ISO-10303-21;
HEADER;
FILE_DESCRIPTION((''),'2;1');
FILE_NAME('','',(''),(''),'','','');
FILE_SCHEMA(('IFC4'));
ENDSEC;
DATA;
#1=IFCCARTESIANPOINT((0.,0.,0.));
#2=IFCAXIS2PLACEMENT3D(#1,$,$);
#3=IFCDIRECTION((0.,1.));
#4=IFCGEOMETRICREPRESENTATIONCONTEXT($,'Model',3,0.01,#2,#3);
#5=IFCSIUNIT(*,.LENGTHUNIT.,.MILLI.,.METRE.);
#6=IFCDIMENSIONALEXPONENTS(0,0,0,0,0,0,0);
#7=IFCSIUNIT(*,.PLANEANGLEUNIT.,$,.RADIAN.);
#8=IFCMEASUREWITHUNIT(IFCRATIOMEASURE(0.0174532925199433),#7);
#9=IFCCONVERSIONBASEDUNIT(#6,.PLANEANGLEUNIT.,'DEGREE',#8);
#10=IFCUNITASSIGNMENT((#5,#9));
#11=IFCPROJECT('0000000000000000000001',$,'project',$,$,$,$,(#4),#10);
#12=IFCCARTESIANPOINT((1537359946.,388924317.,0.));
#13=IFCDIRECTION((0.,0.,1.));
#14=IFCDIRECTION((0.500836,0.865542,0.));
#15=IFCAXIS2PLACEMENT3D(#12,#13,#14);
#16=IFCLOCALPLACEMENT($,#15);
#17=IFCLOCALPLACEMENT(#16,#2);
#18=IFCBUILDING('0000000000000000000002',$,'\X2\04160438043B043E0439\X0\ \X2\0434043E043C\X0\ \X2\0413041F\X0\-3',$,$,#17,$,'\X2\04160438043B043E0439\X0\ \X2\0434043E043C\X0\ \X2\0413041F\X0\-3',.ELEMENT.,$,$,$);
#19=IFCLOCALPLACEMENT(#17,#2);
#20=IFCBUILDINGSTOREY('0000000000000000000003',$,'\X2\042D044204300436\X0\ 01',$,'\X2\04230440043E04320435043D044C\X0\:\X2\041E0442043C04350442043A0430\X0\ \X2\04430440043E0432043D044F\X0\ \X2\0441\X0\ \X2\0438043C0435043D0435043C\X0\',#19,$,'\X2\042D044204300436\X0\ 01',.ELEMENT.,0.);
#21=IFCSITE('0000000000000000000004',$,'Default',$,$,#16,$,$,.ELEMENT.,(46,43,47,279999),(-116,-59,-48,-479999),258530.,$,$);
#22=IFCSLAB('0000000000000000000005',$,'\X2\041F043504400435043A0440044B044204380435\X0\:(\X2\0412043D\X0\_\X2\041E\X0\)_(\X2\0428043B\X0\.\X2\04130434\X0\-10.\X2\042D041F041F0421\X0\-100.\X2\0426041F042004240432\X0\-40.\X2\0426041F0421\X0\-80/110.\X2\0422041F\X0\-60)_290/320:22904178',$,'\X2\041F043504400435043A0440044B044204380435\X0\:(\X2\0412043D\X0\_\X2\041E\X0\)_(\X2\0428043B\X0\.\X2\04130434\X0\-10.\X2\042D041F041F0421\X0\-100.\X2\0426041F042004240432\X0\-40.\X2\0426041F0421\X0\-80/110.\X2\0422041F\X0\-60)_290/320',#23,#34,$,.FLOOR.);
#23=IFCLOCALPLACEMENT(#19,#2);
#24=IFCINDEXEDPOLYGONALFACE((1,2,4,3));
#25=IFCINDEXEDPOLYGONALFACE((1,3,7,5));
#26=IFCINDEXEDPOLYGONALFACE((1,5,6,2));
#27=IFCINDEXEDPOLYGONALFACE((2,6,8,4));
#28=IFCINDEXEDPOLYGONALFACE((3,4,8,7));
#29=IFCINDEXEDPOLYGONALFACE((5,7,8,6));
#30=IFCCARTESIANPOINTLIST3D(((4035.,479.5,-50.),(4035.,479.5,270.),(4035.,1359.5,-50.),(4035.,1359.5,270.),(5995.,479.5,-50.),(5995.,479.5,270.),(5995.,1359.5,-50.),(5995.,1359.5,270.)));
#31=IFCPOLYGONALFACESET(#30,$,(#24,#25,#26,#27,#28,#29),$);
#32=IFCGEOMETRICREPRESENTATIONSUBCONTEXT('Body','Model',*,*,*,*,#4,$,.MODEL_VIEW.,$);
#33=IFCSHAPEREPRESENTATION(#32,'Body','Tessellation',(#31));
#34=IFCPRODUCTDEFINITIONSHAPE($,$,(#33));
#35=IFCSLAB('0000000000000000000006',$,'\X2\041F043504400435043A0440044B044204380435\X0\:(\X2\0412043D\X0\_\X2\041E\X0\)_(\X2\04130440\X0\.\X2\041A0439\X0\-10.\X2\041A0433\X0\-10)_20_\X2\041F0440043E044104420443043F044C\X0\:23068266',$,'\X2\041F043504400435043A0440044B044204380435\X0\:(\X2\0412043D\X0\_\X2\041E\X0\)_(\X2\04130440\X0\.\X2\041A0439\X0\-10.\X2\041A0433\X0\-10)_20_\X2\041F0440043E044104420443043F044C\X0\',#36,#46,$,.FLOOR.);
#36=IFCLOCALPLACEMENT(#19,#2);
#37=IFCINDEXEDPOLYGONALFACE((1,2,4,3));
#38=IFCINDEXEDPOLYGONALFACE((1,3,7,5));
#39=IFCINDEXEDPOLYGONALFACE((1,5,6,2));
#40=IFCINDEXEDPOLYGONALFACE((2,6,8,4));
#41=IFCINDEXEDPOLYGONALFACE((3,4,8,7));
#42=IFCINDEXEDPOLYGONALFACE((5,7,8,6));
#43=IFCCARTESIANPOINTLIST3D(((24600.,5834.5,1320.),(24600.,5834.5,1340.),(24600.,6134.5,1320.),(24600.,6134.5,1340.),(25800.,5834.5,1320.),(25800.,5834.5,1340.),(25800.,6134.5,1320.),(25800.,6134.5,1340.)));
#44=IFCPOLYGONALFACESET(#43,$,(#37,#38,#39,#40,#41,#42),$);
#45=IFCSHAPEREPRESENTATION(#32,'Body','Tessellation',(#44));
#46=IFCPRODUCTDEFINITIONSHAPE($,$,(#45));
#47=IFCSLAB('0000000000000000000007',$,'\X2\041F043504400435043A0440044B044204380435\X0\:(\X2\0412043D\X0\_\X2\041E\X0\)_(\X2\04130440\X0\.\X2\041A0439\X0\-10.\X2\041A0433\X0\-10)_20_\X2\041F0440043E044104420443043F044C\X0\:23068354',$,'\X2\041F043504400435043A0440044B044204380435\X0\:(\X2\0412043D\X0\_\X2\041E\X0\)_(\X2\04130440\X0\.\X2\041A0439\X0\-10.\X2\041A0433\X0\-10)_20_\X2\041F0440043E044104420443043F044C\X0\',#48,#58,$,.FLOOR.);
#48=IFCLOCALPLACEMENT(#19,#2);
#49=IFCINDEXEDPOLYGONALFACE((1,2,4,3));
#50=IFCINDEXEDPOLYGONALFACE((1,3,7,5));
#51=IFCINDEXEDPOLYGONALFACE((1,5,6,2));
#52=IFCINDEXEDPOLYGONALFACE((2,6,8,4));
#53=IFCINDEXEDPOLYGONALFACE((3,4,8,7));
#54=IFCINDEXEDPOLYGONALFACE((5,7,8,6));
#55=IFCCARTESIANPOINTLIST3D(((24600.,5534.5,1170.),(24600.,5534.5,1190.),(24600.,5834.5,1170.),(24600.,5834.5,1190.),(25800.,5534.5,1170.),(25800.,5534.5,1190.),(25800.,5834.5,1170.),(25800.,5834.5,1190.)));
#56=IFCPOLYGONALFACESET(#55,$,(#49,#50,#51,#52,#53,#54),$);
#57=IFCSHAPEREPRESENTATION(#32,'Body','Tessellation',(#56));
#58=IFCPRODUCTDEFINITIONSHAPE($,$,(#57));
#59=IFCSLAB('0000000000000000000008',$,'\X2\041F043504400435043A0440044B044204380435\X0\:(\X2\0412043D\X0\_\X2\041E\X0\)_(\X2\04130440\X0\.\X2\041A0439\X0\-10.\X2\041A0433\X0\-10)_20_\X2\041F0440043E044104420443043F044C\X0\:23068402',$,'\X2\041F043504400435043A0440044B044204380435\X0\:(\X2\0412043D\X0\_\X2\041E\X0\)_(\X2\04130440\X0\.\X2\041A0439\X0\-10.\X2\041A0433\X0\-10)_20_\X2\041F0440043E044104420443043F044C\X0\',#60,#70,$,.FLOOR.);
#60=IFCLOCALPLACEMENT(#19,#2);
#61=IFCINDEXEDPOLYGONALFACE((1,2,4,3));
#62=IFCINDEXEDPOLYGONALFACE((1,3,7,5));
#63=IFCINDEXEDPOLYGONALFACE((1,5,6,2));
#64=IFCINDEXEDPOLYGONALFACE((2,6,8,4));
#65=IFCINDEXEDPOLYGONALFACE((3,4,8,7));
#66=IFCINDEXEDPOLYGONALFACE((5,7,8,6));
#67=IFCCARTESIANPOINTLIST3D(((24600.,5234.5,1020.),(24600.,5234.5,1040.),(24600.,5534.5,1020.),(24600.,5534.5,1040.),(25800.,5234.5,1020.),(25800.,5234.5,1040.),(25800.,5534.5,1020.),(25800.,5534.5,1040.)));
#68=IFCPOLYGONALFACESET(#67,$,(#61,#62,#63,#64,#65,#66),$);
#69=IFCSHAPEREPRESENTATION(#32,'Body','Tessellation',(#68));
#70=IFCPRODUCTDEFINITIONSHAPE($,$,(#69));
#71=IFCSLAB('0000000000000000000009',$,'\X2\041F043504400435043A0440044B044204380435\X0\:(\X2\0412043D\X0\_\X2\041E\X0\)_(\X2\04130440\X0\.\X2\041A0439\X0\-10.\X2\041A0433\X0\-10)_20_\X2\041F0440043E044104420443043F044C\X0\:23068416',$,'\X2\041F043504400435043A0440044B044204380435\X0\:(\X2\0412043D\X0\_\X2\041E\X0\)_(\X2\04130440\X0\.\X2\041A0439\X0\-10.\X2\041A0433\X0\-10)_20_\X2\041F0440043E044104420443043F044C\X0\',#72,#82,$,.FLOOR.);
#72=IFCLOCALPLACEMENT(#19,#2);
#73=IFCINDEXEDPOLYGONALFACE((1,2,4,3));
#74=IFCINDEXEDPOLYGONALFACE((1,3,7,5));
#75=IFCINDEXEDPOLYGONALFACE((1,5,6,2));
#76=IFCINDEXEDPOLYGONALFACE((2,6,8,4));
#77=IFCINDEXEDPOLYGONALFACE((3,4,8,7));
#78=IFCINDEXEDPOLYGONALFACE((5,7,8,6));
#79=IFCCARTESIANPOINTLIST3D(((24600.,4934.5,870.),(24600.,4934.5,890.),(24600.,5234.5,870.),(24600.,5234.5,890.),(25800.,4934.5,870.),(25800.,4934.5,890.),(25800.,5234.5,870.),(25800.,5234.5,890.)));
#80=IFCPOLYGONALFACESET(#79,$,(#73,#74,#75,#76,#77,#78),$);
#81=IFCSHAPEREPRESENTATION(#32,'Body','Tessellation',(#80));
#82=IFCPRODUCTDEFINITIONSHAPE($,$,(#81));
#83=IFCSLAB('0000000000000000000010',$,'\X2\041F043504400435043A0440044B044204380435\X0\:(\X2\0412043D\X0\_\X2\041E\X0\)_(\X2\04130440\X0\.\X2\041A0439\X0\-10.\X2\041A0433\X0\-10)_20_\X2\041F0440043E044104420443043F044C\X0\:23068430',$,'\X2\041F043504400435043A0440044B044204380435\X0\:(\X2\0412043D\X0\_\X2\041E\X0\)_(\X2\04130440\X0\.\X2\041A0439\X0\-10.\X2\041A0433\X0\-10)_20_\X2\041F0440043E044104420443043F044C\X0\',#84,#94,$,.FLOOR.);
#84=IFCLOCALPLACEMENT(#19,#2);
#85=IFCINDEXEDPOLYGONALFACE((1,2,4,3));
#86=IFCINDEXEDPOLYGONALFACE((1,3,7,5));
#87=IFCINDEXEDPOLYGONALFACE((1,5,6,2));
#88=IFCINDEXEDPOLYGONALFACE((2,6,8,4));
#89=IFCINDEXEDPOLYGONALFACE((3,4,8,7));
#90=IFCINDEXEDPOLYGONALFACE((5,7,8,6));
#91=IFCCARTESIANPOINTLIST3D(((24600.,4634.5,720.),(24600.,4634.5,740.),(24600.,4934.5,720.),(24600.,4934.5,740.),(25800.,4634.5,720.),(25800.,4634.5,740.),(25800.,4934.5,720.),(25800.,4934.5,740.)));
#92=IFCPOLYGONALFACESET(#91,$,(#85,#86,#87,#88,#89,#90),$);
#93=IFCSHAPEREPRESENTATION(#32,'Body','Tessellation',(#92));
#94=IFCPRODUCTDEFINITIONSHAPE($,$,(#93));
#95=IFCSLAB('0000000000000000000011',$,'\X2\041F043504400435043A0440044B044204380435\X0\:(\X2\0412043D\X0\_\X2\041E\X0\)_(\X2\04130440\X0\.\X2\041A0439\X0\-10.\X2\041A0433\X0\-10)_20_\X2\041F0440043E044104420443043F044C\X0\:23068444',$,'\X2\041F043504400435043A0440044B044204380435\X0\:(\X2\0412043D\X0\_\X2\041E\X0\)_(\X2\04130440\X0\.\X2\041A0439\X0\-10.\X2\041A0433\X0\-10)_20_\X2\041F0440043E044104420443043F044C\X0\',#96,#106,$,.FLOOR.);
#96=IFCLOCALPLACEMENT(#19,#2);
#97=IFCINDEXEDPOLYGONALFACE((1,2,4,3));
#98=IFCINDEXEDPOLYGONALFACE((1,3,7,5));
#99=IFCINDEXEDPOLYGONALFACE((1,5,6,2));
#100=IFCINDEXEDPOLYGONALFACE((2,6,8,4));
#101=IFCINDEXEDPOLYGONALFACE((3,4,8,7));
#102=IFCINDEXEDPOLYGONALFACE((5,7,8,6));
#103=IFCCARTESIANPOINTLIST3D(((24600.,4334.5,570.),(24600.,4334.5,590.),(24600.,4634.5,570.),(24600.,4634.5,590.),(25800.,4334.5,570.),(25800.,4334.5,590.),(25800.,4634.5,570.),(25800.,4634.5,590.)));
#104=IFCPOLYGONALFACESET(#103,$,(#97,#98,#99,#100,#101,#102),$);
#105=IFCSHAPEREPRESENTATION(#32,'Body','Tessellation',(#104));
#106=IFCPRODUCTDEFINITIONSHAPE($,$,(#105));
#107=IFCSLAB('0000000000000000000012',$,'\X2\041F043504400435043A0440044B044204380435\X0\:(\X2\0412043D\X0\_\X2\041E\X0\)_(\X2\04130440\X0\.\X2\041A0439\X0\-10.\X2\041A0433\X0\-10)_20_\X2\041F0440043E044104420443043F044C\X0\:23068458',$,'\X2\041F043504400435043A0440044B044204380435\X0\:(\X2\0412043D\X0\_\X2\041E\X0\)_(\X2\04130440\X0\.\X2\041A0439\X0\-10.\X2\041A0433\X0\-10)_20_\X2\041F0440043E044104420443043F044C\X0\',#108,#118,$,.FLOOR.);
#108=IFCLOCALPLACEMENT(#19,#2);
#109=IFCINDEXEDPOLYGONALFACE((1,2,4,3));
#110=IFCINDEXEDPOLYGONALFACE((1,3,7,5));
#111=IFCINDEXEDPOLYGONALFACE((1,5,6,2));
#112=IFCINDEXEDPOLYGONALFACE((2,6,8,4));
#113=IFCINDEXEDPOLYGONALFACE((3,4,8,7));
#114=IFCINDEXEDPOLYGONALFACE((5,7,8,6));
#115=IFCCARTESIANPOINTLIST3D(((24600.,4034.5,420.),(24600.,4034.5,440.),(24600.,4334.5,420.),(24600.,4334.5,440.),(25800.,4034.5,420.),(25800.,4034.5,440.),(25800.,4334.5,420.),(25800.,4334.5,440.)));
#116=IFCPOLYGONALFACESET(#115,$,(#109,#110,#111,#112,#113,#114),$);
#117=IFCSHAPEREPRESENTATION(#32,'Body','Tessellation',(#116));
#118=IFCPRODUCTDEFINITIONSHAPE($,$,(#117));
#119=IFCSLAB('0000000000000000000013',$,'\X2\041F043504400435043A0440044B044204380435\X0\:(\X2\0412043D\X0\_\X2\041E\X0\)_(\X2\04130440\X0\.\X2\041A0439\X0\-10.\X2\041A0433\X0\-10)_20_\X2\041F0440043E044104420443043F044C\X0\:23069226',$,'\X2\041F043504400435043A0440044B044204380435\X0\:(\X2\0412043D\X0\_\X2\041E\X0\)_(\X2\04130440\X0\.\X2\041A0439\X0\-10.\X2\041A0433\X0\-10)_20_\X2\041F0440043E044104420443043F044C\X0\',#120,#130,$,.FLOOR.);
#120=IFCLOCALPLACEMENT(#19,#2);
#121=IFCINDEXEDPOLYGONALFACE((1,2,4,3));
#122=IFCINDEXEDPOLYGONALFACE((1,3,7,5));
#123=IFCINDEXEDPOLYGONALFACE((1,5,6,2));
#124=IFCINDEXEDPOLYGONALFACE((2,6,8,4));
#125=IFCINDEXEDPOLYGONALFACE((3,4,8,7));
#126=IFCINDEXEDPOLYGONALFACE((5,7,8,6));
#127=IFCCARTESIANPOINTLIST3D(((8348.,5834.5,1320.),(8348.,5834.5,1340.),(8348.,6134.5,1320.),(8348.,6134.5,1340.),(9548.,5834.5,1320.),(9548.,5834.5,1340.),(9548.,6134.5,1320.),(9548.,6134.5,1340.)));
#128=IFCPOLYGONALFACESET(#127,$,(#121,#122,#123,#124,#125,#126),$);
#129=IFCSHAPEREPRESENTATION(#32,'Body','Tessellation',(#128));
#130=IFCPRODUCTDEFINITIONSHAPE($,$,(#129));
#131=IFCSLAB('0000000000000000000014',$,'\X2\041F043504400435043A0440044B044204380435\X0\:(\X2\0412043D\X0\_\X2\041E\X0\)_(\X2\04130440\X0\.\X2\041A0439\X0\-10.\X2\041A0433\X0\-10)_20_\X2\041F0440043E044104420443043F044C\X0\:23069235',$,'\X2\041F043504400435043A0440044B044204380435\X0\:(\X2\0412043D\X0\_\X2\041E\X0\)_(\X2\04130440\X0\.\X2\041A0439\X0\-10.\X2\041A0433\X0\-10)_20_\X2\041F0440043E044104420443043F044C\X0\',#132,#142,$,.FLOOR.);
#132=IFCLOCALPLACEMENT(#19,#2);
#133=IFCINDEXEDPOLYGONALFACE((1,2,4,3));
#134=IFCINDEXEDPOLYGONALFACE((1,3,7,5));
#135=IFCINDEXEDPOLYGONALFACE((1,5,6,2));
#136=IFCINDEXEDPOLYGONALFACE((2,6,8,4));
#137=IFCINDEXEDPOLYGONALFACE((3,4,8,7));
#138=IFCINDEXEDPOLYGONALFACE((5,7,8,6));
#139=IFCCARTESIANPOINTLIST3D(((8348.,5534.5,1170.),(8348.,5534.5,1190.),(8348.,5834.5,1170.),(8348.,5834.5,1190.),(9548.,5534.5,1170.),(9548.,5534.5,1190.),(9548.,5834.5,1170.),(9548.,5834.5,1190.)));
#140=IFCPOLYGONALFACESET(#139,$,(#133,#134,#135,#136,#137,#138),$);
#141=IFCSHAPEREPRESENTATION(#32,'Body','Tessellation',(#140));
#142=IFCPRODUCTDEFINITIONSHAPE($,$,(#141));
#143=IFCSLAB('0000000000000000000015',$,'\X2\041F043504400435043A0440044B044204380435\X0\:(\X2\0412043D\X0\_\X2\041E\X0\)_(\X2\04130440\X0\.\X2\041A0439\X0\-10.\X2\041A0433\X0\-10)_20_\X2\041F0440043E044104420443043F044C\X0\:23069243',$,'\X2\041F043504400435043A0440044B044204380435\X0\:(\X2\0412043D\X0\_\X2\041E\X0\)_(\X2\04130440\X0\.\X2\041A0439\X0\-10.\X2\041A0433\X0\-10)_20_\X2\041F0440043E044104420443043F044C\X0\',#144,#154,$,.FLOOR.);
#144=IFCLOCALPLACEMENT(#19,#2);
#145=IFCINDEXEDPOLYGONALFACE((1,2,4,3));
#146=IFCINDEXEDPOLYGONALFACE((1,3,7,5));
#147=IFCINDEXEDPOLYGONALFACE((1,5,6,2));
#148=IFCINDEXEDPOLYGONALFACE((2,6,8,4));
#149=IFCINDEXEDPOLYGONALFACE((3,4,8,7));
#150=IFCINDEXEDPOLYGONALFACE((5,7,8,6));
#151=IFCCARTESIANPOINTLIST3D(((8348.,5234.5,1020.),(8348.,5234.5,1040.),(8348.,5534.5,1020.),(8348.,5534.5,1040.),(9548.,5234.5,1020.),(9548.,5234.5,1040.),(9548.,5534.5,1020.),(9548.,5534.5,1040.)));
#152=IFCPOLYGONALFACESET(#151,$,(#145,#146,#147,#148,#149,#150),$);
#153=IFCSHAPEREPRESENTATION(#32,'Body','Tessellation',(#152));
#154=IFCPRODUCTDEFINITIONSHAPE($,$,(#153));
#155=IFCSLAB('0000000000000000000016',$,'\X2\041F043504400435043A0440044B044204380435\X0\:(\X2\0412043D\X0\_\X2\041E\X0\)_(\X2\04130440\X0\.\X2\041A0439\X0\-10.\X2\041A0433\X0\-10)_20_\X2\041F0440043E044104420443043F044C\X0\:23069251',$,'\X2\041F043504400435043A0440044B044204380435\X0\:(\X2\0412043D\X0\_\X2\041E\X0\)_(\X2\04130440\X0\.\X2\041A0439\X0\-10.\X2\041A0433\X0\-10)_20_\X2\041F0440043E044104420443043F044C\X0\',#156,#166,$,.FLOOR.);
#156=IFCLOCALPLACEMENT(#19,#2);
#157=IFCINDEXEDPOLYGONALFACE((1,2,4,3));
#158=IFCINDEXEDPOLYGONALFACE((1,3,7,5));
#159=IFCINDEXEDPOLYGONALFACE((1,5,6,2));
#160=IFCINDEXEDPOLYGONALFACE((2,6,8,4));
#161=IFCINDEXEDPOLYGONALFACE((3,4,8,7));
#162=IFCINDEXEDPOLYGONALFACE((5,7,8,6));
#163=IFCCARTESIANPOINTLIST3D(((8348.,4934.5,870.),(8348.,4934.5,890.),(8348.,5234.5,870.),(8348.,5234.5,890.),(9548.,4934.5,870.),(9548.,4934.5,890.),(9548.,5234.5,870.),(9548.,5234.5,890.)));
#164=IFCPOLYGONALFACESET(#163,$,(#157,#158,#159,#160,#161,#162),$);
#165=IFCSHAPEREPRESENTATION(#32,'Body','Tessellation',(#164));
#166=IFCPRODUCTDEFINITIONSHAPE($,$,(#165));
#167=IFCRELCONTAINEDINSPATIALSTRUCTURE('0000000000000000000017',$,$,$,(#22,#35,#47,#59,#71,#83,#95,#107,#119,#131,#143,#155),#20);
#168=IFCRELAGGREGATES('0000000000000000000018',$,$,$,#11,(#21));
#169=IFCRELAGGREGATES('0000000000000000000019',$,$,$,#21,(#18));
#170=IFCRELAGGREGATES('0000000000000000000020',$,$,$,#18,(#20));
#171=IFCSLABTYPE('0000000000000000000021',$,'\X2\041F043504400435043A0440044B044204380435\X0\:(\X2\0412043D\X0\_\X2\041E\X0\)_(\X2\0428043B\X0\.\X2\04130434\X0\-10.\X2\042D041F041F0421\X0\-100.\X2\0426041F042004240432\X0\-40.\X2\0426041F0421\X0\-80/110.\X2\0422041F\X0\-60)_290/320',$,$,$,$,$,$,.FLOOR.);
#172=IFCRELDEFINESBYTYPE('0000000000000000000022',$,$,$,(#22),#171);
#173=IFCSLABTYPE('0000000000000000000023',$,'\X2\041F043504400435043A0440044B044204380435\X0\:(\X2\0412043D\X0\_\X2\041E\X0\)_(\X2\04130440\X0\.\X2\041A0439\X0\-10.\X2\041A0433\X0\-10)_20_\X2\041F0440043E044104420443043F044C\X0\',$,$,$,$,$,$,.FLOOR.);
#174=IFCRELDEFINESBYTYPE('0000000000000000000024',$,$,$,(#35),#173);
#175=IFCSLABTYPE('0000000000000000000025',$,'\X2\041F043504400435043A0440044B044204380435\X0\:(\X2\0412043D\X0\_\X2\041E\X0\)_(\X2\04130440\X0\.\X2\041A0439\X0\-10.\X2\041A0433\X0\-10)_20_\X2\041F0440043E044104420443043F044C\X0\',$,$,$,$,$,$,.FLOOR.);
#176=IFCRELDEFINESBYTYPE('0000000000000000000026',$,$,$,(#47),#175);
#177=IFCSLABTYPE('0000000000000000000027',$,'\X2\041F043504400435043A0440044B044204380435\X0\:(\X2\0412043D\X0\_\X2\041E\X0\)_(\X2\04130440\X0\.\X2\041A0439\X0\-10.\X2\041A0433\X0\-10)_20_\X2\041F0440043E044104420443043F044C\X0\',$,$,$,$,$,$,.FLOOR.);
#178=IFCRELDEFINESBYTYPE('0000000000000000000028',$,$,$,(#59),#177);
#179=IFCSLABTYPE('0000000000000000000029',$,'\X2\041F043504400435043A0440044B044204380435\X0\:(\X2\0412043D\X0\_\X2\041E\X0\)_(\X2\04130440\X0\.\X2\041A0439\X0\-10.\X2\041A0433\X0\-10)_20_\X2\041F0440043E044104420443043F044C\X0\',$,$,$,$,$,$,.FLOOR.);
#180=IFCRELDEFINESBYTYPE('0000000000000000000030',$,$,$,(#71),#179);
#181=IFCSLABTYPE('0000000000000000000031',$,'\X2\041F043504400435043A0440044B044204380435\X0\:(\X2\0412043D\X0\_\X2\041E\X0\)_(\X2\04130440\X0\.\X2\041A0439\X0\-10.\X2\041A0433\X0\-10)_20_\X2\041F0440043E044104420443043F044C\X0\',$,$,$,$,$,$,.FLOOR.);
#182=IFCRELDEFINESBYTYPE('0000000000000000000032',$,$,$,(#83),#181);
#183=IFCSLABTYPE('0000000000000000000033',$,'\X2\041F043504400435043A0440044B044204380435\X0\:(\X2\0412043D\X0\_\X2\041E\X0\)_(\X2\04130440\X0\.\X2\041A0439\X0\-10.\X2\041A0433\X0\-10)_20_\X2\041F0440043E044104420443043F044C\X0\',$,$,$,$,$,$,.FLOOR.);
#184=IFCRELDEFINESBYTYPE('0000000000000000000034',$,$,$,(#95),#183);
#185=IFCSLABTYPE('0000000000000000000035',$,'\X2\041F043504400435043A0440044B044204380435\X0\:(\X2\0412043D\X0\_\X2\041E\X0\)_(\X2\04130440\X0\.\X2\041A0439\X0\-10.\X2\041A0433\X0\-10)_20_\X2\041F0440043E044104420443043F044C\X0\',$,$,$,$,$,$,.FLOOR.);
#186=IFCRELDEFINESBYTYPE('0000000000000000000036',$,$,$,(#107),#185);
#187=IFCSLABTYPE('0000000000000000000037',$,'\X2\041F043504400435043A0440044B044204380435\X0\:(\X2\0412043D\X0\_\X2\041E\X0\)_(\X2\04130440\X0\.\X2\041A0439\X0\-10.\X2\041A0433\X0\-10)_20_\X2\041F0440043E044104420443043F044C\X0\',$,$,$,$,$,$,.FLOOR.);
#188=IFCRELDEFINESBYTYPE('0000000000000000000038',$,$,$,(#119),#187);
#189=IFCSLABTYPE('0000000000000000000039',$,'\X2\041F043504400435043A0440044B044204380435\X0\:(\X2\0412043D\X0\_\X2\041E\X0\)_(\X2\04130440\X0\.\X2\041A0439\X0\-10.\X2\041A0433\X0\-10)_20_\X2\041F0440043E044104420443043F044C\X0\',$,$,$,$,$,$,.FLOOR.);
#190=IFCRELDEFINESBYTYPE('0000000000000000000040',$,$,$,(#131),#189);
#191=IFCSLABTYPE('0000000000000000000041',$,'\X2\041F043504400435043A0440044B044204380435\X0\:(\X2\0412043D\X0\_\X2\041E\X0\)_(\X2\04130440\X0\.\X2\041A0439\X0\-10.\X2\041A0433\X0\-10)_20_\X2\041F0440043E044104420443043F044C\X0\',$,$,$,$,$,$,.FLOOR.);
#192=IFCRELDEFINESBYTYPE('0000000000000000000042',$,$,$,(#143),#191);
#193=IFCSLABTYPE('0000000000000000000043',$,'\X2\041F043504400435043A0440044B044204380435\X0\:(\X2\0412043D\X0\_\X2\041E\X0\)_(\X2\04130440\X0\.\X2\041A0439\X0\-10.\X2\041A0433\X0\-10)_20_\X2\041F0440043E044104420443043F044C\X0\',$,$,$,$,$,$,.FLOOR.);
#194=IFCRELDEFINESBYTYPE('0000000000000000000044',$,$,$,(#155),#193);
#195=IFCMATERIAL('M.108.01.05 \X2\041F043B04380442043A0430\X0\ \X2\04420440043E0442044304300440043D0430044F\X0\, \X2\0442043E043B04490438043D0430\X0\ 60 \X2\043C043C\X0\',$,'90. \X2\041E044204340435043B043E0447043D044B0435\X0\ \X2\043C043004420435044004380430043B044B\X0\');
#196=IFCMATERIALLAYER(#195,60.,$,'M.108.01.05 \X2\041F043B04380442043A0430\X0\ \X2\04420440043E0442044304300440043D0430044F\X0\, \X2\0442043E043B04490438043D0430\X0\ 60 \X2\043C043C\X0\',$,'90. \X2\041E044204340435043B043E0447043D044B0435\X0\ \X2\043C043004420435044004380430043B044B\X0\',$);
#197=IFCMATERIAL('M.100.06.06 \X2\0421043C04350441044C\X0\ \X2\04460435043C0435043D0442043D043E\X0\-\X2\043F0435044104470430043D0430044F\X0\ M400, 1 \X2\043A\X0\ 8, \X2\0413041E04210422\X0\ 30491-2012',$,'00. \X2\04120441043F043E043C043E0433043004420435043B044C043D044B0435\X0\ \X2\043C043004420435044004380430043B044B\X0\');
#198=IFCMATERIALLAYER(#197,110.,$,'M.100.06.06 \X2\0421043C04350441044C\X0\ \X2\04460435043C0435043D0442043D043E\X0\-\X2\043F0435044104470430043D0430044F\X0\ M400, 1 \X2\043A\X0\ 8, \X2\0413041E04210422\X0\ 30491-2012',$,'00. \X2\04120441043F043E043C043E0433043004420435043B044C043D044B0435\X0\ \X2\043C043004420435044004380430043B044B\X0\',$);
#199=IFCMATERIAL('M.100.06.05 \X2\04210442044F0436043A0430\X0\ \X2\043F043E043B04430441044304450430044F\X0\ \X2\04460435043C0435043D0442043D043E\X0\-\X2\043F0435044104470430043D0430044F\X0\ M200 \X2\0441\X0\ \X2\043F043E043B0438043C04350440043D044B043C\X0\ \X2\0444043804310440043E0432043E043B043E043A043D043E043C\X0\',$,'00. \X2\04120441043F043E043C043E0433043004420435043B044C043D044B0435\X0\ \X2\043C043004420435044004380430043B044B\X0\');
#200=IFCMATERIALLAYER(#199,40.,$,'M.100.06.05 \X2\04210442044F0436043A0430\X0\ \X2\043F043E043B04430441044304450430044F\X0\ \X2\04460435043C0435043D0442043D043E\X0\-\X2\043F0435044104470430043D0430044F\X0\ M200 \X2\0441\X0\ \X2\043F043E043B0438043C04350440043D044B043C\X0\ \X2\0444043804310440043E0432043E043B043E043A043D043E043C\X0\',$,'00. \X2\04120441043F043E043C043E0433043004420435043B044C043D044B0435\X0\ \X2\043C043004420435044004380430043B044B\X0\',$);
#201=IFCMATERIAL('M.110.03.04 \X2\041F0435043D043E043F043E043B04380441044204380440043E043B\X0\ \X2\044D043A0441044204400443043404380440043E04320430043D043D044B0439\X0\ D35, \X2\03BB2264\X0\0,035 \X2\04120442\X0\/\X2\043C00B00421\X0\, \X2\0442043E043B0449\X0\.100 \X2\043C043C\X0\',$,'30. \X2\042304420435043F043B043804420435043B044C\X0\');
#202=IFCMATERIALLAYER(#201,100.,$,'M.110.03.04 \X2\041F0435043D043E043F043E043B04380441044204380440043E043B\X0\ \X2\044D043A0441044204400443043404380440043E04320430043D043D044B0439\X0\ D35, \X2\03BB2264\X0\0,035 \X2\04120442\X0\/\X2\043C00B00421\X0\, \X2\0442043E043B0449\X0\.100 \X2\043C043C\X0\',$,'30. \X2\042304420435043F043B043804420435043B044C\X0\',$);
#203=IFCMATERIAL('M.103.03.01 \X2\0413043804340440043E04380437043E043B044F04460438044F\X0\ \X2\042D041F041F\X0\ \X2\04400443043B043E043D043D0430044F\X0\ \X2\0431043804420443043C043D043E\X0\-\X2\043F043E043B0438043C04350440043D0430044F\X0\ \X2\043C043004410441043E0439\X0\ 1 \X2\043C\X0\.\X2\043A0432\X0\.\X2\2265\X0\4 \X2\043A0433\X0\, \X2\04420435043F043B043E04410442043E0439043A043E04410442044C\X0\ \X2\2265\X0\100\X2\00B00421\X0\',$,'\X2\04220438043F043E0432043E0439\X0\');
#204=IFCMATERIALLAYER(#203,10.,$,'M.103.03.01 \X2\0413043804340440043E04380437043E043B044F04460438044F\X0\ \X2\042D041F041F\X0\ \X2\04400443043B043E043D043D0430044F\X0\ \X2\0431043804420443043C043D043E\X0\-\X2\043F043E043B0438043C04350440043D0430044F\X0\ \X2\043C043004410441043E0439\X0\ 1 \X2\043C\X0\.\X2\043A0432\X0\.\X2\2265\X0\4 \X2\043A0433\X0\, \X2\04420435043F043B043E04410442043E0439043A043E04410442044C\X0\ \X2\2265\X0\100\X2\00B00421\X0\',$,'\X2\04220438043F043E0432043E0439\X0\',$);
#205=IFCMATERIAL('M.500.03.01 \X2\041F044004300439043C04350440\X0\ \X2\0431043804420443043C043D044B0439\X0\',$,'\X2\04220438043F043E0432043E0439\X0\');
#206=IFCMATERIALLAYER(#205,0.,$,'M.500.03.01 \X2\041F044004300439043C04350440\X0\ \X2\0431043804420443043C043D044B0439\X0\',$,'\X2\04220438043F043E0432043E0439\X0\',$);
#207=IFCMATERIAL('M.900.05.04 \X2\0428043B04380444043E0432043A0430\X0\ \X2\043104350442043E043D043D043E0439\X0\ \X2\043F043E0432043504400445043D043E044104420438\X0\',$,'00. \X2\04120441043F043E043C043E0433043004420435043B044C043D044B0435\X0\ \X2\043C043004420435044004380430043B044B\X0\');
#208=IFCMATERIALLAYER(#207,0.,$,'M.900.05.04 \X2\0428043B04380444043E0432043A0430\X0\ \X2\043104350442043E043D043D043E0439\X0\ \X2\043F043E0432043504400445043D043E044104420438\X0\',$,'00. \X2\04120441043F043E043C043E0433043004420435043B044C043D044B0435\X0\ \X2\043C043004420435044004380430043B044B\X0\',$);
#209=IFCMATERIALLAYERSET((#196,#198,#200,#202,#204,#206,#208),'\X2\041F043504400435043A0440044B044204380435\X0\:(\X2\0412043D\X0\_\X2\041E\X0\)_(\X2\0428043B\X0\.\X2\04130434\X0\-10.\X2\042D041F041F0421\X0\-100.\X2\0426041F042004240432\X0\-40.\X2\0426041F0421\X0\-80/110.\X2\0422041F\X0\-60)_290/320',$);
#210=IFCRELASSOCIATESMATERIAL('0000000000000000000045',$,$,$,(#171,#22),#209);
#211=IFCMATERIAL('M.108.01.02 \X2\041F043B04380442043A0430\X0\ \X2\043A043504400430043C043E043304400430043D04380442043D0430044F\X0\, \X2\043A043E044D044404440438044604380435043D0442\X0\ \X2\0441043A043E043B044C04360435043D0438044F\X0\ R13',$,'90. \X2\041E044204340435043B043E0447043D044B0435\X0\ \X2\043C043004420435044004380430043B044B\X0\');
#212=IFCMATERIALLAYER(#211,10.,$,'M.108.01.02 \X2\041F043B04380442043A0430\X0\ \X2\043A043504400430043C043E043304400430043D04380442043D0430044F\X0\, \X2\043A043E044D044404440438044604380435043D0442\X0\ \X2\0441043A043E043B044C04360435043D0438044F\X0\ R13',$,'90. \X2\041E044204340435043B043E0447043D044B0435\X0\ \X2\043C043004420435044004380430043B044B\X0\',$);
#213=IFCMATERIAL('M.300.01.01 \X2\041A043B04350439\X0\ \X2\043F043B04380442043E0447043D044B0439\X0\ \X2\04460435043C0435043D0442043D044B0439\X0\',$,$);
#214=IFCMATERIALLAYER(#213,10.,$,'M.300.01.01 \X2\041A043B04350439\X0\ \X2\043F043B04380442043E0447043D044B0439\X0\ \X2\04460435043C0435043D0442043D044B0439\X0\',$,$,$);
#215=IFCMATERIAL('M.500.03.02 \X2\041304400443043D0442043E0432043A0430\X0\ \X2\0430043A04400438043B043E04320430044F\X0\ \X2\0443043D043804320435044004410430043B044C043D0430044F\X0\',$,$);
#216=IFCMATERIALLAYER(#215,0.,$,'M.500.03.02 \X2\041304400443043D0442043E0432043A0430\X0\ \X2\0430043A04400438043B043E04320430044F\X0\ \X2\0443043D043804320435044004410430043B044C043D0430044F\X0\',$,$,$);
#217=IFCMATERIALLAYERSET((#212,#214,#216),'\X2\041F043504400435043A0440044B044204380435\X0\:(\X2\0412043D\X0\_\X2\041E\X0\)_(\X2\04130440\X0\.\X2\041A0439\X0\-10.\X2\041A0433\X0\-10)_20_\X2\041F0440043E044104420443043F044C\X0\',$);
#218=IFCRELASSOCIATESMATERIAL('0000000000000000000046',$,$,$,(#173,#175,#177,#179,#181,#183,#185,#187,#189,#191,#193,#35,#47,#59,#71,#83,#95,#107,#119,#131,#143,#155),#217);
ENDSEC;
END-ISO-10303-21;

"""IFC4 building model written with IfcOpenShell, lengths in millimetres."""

from ifc_helpers import new_model, entity, si_unit, converted_unit, direction, frame, frame_2d, origin, place, context, subcontext, project, spatial, rectangle, extrude, material, layer, layer_set, layer_usage, type_object, element, save


model = new_model("IFC4")

# Units and contexts
model_context = context("Model", 3, precision=0.01, world=origin(), true_north=direction((0.0, 1.0)))
body_context = subcontext(model_context, "Body", "Model", "MODEL_VIEW")
ifc_project = project(units=[si_unit("LENGTHUNIT", "METRE", prefix="MILLI"), converted_unit("PLANEANGLEUNIT", "DEGREE", entity("IfcRatioMeasure", 0.0174532925199433), si_unit("PLANEANGLEUNIT", "RADIAN"), dimensions=[0, 0, 0, 0, 0, 0, 0])], contexts=[model_context])

# Site, building, storey
site_placement = place(None, frame((1537359946.0, 388924317.0, 0.0), z_axis=(0.0, 0.0, 1.0), x_axis=(0.500836, 0.865542, 0.0)))
site = spatial("IfcSite", under=ifc_project, at=site_placement, Name="Default", CompositionType="ELEMENT", RefLatitude=(46, 43, 47, 279999), RefLongitude=(-116, -59, -48, -479999), RefElevation=258530.0)
building_placement = place(site_placement, origin())
building = spatial("IfcBuilding", under=site, at=building_placement, Name="Жилой дом ГП-3", LongName="Жилой дом ГП-3", CompositionType="ELEMENT")
storey_placement = place(building_placement, origin())
storey = spatial("IfcBuildingStorey", under=building, at=storey_placement, Name="Этаж 01", ObjectType="Уровень:Отметка уровня с именем", LongName="Этаж 01", CompositionType="ELEMENT", Elevation=0.0)

# Slabs
ifc_material_1 = material(Name="M.108.01.05 Плитка тротуарная, толщина 60 мм", Category="90. Отделочные материалы")
ifc_layer_1 = layer(ifc_material_1, 60.0, Name="M.108.01.05 Плитка тротуарная, толщина 60 мм", Category="90. Отделочные материалы")
ifc_material_2 = material(Name="M.100.06.06 Смесь цементно-песчаная M400, 1 к 8, ГОСТ 30491-2012", Category="00. Вспомогательные материалы")
ifc_layer_2 = layer(ifc_material_2, 110.0, Name="M.100.06.06 Смесь цементно-песчаная M400, 1 к 8, ГОСТ 30491-2012", Category="00. Вспомогательные материалы")
ifc_material_3 = material(Name="M.100.06.05 Стяжка полусухая цементно-песчаная M200 с полимерным фиброволокном", Category="00. Вспомогательные материалы")
ifc_layer_3 = layer(ifc_material_3, 40.0, Name="M.100.06.05 Стяжка полусухая цементно-песчаная M200 с полимерным фиброволокном", Category="00. Вспомогательные материалы")
ifc_material_4 = material(Name="M.110.03.04 Пенополистирол экструдированный D35, λ≤0,035 Вт/м°С, толщ.100 мм", Category="30. Утеплитель")
ifc_layer_4 = layer(ifc_material_4, 100.0, Name="M.110.03.04 Пенополистирол экструдированный D35, λ≤0,035 Вт/м°С, толщ.100 мм", Category="30. Утеплитель")
ifc_material_5 = material(Name="M.103.03.01 Гидроизоляция ЭПП рулонная битумно-полимерная массой 1 м.кв.≥4 кг, теплостойкость ≥100°С", Category="Типовой")
ifc_layer_5 = layer(ifc_material_5, 10.0, Name="M.103.03.01 Гидроизоляция ЭПП рулонная битумно-полимерная массой 1 м.кв.≥4 кг, теплостойкость ≥100°С", Category="Типовой")
ifc_material_6 = material(Name="M.500.03.01 Праймер битумный", Category="Типовой")
ifc_layer_6 = layer(ifc_material_6, 0.0, Name="M.500.03.01 Праймер битумный", Category="Типовой")
ifc_material_7 = material(Name="M.900.05.04 Шлифовка бетонной поверхности", Category="00. Вспомогательные материалы")
ifc_layer_7 = layer(ifc_material_7, 0.0, Name="M.900.05.04 Шлифовка бетонной поверхности", Category="00. Вспомогательные материалы")
ifc_layer_set_1 = layer_set([ifc_layer_1, ifc_layer_2, ifc_layer_3, ifc_layer_4, ifc_layer_5, ifc_layer_6, ifc_layer_7], Name="Перекрытие:(Вн_О)_(Шл.Гд-10.ЭППС-100.ЦПРФв-40.ЦПС-80/110.ТП-60)_290/320")
ifc_layer_usage_1 = layer_usage(ifc_layer_set_1, "AXIS3", "POSITIVE", 0.0)
slab_type_1 = type_object("IfcSlabType", Name="Перекрытие:(Вн_О)_(Шл.Гд-10.ЭППС-100.ЦПРФв-40.ЦПС-80/110.ТП-60)_290/320", PredefinedType="FLOOR", material=ifc_layer_set_1)
slab_1_placement = place(storey_placement, origin())
element("IfcSlab", 1, at=slab_1_placement, inside=storey, type_object=slab_type_1, material=ifc_layer_usage_1, Name="Перекрытие:(Вн_О)_(Шл.Гд-10.ЭППС-100.ЦПРФв-40.ЦПС-80/110.ТП-60)_290/320:22904178", ObjectType="Перекрытие:(Вн_О)_(Шл.Гд-10.ЭППС-100.ЦПРФв-40.ЦПС-80/110.ТП-60)_290/320", PredefinedType="FLOOR", context=body_context, shape_type="SweptSolid", body=[
    extrude(rectangle(XDim=880.0, YDim=1960.0, at=frame_2d((0.0, 0.0), x_axis=(1.0, 0.0))), frame((5015.0, 919.5, 270.0), z_axis=(0.0, 0.0, -1.0), x_axis=(0.0, 1.0, 0.0)), (0.0, 0.0, 1.0), 320.0),
])
ifc_material_8 = material(Name="M.108.01.02 Плитка керамогранитная, коэффициент скольжения R13", Category="90. Отделочные материалы")
ifc_layer_8 = layer(ifc_material_8, 10.0, Name="M.108.01.02 Плитка керамогранитная, коэффициент скольжения R13", Category="90. Отделочные материалы")
ifc_material_9 = material(Name="M.300.01.01 Клей плиточный цементный")
ifc_layer_9 = layer(ifc_material_9, 10.0, Name="M.300.01.01 Клей плиточный цементный")
ifc_material_10 = material(Name="M.500.03.02 Грунтовка акриловая универсальная")
ifc_layer_10 = layer(ifc_material_10, 0.0, Name="M.500.03.02 Грунтовка акриловая универсальная")
ifc_layer_set_2 = layer_set([ifc_layer_8, ifc_layer_9, ifc_layer_10], Name="Перекрытие:(Вн_О)_(Гр.Кй-10.Кг-10)_20_Проступь")
ifc_layer_usage_2 = layer_usage(ifc_layer_set_2, "AXIS3", "POSITIVE", 0.0)
slab_type_2 = type_object("IfcSlabType", Name="Перекрытие:(Вн_О)_(Гр.Кй-10.Кг-10)_20_Проступь", PredefinedType="FLOOR", material=ifc_layer_set_2)
slab_2_placement = place(storey_placement, origin())
element("IfcSlab", 2, at=slab_2_placement, inside=storey, type_object=slab_type_2, material=ifc_layer_usage_2, Name="Перекрытие:(Вн_О)_(Гр.Кй-10.Кг-10)_20_Проступь:23068266", ObjectType="Перекрытие:(Вн_О)_(Гр.Кй-10.Кг-10)_20_Проступь", PredefinedType="FLOOR", context=body_context, shape_type="SweptSolid", body=[
    extrude(rectangle(XDim=300.0, YDim=1200.0, at=frame_2d((0.0, 0.0), x_axis=(1.0, 0.0))), frame((25200.0, 5984.5, 1340.0), z_axis=(0.0, 0.0, -1.0), x_axis=(0.0, 1.0, 0.0)), (0.0, 0.0, 1.0), 20.0),
])
ifc_layer_usage_3 = layer_usage(ifc_layer_set_2, "AXIS3", "POSITIVE", 0.0)
slab_type_3 = type_object("IfcSlabType", Name="Перекрытие:(Вн_О)_(Гр.Кй-10.Кг-10)_20_Проступь", PredefinedType="FLOOR", material=ifc_layer_set_2)
slab_3_placement = place(storey_placement, origin())
element("IfcSlab", 3, at=slab_3_placement, inside=storey, type_object=slab_type_3, material=ifc_layer_usage_3, Name="Перекрытие:(Вн_О)_(Гр.Кй-10.Кг-10)_20_Проступь:23068354", ObjectType="Перекрытие:(Вн_О)_(Гр.Кй-10.Кг-10)_20_Проступь", PredefinedType="FLOOR", context=body_context, shape_type="SweptSolid", body=[
    extrude(rectangle(XDim=300.0, YDim=1200.0, at=frame_2d((0.0, 0.0), x_axis=(1.0, 0.0))), frame((25200.0, 5684.5, 1190.0), z_axis=(0.0, 0.0, -1.0), x_axis=(0.0, 1.0, 0.0)), (0.0, 0.0, 1.0), 20.0),
])
ifc_layer_usage_4 = layer_usage(ifc_layer_set_2, "AXIS3", "POSITIVE", 0.0)
slab_type_4 = type_object("IfcSlabType", Name="Перекрытие:(Вн_О)_(Гр.Кй-10.Кг-10)_20_Проступь", PredefinedType="FLOOR", material=ifc_layer_set_2)
slab_4_placement = place(storey_placement, origin())
element("IfcSlab", 4, at=slab_4_placement, inside=storey, type_object=slab_type_4, material=ifc_layer_usage_4, Name="Перекрытие:(Вн_О)_(Гр.Кй-10.Кг-10)_20_Проступь:23068402", ObjectType="Перекрытие:(Вн_О)_(Гр.Кй-10.Кг-10)_20_Проступь", PredefinedType="FLOOR", context=body_context, shape_type="SweptSolid", body=[
    extrude(rectangle(XDim=300.0, YDim=1200.0, at=frame_2d((0.0, 0.0), x_axis=(1.0, 0.0))), frame((25200.0, 5384.5, 1040.0), z_axis=(0.0, 0.0, -1.0), x_axis=(0.0, 1.0, 0.0)), (0.0, 0.0, 1.0), 20.0),
])
ifc_layer_usage_5 = layer_usage(ifc_layer_set_2, "AXIS3", "POSITIVE", 0.0)
slab_type_5 = type_object("IfcSlabType", Name="Перекрытие:(Вн_О)_(Гр.Кй-10.Кг-10)_20_Проступь", PredefinedType="FLOOR", material=ifc_layer_set_2)
slab_5_placement = place(storey_placement, origin())
element("IfcSlab", 5, at=slab_5_placement, inside=storey, type_object=slab_type_5, material=ifc_layer_usage_5, Name="Перекрытие:(Вн_О)_(Гр.Кй-10.Кг-10)_20_Проступь:23068416", ObjectType="Перекрытие:(Вн_О)_(Гр.Кй-10.Кг-10)_20_Проступь", PredefinedType="FLOOR", context=body_context, shape_type="SweptSolid", body=[
    extrude(rectangle(XDim=300.0, YDim=1200.0, at=frame_2d((0.0, 0.0), x_axis=(1.0, 0.0))), frame((25200.0, 5084.5, 890.0), z_axis=(0.0, 0.0, -1.0), x_axis=(0.0, 1.0, 0.0)), (0.0, 0.0, 1.0), 20.0),
])
ifc_layer_usage_6 = layer_usage(ifc_layer_set_2, "AXIS3", "POSITIVE", 0.0)
slab_type_6 = type_object("IfcSlabType", Name="Перекрытие:(Вн_О)_(Гр.Кй-10.Кг-10)_20_Проступь", PredefinedType="FLOOR", material=ifc_layer_set_2)
slab_6_placement = place(storey_placement, origin())
element("IfcSlab", 6, at=slab_6_placement, inside=storey, type_object=slab_type_6, material=ifc_layer_usage_6, Name="Перекрытие:(Вн_О)_(Гр.Кй-10.Кг-10)_20_Проступь:23068430", ObjectType="Перекрытие:(Вн_О)_(Гр.Кй-10.Кг-10)_20_Проступь", PredefinedType="FLOOR", context=body_context, shape_type="SweptSolid", body=[
    extrude(rectangle(XDim=300.0, YDim=1200.0, at=frame_2d((0.0, 0.0), x_axis=(1.0, 0.0))), frame((25200.0, 4784.5, 740.0), z_axis=(0.0, 0.0, -1.0), x_axis=(0.0, 1.0, 0.0)), (0.0, 0.0, 1.0), 20.0),
])
ifc_layer_usage_7 = layer_usage(ifc_layer_set_2, "AXIS3", "POSITIVE", 0.0)
slab_type_7 = type_object("IfcSlabType", Name="Перекрытие:(Вн_О)_(Гр.Кй-10.Кг-10)_20_Проступь", PredefinedType="FLOOR", material=ifc_layer_set_2)
slab_7_placement = place(storey_placement, origin())
element("IfcSlab", 7, at=slab_7_placement, inside=storey, type_object=slab_type_7, material=ifc_layer_usage_7, Name="Перекрытие:(Вн_О)_(Гр.Кй-10.Кг-10)_20_Проступь:23068444", ObjectType="Перекрытие:(Вн_О)_(Гр.Кй-10.Кг-10)_20_Проступь", PredefinedType="FLOOR", context=body_context, shape_type="SweptSolid", body=[
    extrude(rectangle(XDim=300.0, YDim=1200.0, at=frame_2d((0.0, 0.0), x_axis=(1.0, 0.0))), frame((25200.0, 4484.5, 590.0), z_axis=(0.0, 0.0, -1.0), x_axis=(0.0, 1.0, 0.0)), (0.0, 0.0, 1.0), 20.0),
])
ifc_layer_usage_8 = layer_usage(ifc_layer_set_2, "AXIS3", "POSITIVE", 0.0)
slab_type_8 = type_object("IfcSlabType", Name="Перекрытие:(Вн_О)_(Гр.Кй-10.Кг-10)_20_Проступь", PredefinedType="FLOOR", material=ifc_layer_set_2)
slab_8_placement = place(storey_placement, origin())
element("IfcSlab", 8, at=slab_8_placement, inside=storey, type_object=slab_type_8, material=ifc_layer_usage_8, Name="Перекрытие:(Вн_О)_(Гр.Кй-10.Кг-10)_20_Проступь:23068458", ObjectType="Перекрытие:(Вн_О)_(Гр.Кй-10.Кг-10)_20_Проступь", PredefinedType="FLOOR", context=body_context, shape_type="SweptSolid", body=[
    extrude(rectangle(XDim=300.0, YDim=1200.0, at=frame_2d((0.0, 0.0), x_axis=(1.0, 0.0))), frame((25200.0, 4184.5, 440.0), z_axis=(0.0, 0.0, -1.0), x_axis=(0.0, 1.0, 0.0)), (0.0, 0.0, 1.0), 20.0),
])
ifc_layer_usage_9 = layer_usage(ifc_layer_set_2, "AXIS3", "POSITIVE", 0.0)
slab_type_9 = type_object("IfcSlabType", Name="Перекрытие:(Вн_О)_(Гр.Кй-10.Кг-10)_20_Проступь", PredefinedType="FLOOR", material=ifc_layer_set_2)
slab_9_placement = place(storey_placement, origin())
element("IfcSlab", 9, at=slab_9_placement, inside=storey, type_object=slab_type_9, material=ifc_layer_usage_9, Name="Перекрытие:(Вн_О)_(Гр.Кй-10.Кг-10)_20_Проступь:23069226", ObjectType="Перекрытие:(Вн_О)_(Гр.Кй-10.Кг-10)_20_Проступь", PredefinedType="FLOOR", context=body_context, shape_type="SweptSolid", body=[
    extrude(rectangle(XDim=300.0, YDim=1200.0, at=frame_2d((0.0, 0.0), x_axis=(1.0, 0.0))), frame((8948.0, 5984.5, 1340.0), z_axis=(0.0, 0.0, -1.0), x_axis=(0.0, 1.0, 0.0)), (0.0, 0.0, 1.0), 20.0),
])
ifc_layer_usage_10 = layer_usage(ifc_layer_set_2, "AXIS3", "POSITIVE", 0.0)
slab_type_10 = type_object("IfcSlabType", Name="Перекрытие:(Вн_О)_(Гр.Кй-10.Кг-10)_20_Проступь", PredefinedType="FLOOR", material=ifc_layer_set_2)
slab_10_placement = place(storey_placement, origin())
element("IfcSlab", 10, at=slab_10_placement, inside=storey, type_object=slab_type_10, material=ifc_layer_usage_10, Name="Перекрытие:(Вн_О)_(Гр.Кй-10.Кг-10)_20_Проступь:23069235", ObjectType="Перекрытие:(Вн_О)_(Гр.Кй-10.Кг-10)_20_Проступь", PredefinedType="FLOOR", context=body_context, shape_type="SweptSolid", body=[
    extrude(rectangle(XDim=300.0, YDim=1200.0, at=frame_2d((0.0, 0.0), x_axis=(1.0, 0.0))), frame((8948.0, 5684.5, 1190.0), z_axis=(0.0, 0.0, -1.0), x_axis=(0.0, 1.0, 0.0)), (0.0, 0.0, 1.0), 20.0),
])
ifc_layer_usage_11 = layer_usage(ifc_layer_set_2, "AXIS3", "POSITIVE", 0.0)
slab_type_11 = type_object("IfcSlabType", Name="Перекрытие:(Вн_О)_(Гр.Кй-10.Кг-10)_20_Проступь", PredefinedType="FLOOR", material=ifc_layer_set_2)
slab_11_placement = place(storey_placement, origin())
element("IfcSlab", 11, at=slab_11_placement, inside=storey, type_object=slab_type_11, material=ifc_layer_usage_11, Name="Перекрытие:(Вн_О)_(Гр.Кй-10.Кг-10)_20_Проступь:23069243", ObjectType="Перекрытие:(Вн_О)_(Гр.Кй-10.Кг-10)_20_Проступь", PredefinedType="FLOOR", context=body_context, shape_type="SweptSolid", body=[
    extrude(rectangle(XDim=300.0, YDim=1200.0, at=frame_2d((0.0, 0.0), x_axis=(1.0, 0.0))), frame((8948.0, 5384.5, 1040.0), z_axis=(0.0, 0.0, -1.0), x_axis=(0.0, 1.0, 0.0)), (0.0, 0.0, 1.0), 20.0),
])
ifc_layer_usage_12 = layer_usage(ifc_layer_set_2, "AXIS3", "POSITIVE", 0.0)
slab_type_12 = type_object("IfcSlabType", Name="Перекрытие:(Вн_О)_(Гр.Кй-10.Кг-10)_20_Проступь", PredefinedType="FLOOR", material=ifc_layer_set_2)
slab_12_placement = place(storey_placement, origin())
element("IfcSlab", 12, at=slab_12_placement, inside=storey, type_object=slab_type_12, material=ifc_layer_usage_12, Name="Перекрытие:(Вн_О)_(Гр.Кй-10.Кг-10)_20_Проступь:23069251", ObjectType="Перекрытие:(Вн_О)_(Гр.Кй-10.Кг-10)_20_Проступь", PredefinedType="FLOOR", context=body_context, shape_type="SweptSolid", body=[
    extrude(rectangle(XDim=300.0, YDim=1200.0, at=frame_2d((0.0, 0.0), x_axis=(1.0, 0.0))), frame((8948.0, 5084.5, 890.0), z_axis=(0.0, 0.0, -1.0), x_axis=(0.0, 1.0, 0.0)), (0.0, 0.0, 1.0), 20.0),
])

save(model, "model.ifc")
